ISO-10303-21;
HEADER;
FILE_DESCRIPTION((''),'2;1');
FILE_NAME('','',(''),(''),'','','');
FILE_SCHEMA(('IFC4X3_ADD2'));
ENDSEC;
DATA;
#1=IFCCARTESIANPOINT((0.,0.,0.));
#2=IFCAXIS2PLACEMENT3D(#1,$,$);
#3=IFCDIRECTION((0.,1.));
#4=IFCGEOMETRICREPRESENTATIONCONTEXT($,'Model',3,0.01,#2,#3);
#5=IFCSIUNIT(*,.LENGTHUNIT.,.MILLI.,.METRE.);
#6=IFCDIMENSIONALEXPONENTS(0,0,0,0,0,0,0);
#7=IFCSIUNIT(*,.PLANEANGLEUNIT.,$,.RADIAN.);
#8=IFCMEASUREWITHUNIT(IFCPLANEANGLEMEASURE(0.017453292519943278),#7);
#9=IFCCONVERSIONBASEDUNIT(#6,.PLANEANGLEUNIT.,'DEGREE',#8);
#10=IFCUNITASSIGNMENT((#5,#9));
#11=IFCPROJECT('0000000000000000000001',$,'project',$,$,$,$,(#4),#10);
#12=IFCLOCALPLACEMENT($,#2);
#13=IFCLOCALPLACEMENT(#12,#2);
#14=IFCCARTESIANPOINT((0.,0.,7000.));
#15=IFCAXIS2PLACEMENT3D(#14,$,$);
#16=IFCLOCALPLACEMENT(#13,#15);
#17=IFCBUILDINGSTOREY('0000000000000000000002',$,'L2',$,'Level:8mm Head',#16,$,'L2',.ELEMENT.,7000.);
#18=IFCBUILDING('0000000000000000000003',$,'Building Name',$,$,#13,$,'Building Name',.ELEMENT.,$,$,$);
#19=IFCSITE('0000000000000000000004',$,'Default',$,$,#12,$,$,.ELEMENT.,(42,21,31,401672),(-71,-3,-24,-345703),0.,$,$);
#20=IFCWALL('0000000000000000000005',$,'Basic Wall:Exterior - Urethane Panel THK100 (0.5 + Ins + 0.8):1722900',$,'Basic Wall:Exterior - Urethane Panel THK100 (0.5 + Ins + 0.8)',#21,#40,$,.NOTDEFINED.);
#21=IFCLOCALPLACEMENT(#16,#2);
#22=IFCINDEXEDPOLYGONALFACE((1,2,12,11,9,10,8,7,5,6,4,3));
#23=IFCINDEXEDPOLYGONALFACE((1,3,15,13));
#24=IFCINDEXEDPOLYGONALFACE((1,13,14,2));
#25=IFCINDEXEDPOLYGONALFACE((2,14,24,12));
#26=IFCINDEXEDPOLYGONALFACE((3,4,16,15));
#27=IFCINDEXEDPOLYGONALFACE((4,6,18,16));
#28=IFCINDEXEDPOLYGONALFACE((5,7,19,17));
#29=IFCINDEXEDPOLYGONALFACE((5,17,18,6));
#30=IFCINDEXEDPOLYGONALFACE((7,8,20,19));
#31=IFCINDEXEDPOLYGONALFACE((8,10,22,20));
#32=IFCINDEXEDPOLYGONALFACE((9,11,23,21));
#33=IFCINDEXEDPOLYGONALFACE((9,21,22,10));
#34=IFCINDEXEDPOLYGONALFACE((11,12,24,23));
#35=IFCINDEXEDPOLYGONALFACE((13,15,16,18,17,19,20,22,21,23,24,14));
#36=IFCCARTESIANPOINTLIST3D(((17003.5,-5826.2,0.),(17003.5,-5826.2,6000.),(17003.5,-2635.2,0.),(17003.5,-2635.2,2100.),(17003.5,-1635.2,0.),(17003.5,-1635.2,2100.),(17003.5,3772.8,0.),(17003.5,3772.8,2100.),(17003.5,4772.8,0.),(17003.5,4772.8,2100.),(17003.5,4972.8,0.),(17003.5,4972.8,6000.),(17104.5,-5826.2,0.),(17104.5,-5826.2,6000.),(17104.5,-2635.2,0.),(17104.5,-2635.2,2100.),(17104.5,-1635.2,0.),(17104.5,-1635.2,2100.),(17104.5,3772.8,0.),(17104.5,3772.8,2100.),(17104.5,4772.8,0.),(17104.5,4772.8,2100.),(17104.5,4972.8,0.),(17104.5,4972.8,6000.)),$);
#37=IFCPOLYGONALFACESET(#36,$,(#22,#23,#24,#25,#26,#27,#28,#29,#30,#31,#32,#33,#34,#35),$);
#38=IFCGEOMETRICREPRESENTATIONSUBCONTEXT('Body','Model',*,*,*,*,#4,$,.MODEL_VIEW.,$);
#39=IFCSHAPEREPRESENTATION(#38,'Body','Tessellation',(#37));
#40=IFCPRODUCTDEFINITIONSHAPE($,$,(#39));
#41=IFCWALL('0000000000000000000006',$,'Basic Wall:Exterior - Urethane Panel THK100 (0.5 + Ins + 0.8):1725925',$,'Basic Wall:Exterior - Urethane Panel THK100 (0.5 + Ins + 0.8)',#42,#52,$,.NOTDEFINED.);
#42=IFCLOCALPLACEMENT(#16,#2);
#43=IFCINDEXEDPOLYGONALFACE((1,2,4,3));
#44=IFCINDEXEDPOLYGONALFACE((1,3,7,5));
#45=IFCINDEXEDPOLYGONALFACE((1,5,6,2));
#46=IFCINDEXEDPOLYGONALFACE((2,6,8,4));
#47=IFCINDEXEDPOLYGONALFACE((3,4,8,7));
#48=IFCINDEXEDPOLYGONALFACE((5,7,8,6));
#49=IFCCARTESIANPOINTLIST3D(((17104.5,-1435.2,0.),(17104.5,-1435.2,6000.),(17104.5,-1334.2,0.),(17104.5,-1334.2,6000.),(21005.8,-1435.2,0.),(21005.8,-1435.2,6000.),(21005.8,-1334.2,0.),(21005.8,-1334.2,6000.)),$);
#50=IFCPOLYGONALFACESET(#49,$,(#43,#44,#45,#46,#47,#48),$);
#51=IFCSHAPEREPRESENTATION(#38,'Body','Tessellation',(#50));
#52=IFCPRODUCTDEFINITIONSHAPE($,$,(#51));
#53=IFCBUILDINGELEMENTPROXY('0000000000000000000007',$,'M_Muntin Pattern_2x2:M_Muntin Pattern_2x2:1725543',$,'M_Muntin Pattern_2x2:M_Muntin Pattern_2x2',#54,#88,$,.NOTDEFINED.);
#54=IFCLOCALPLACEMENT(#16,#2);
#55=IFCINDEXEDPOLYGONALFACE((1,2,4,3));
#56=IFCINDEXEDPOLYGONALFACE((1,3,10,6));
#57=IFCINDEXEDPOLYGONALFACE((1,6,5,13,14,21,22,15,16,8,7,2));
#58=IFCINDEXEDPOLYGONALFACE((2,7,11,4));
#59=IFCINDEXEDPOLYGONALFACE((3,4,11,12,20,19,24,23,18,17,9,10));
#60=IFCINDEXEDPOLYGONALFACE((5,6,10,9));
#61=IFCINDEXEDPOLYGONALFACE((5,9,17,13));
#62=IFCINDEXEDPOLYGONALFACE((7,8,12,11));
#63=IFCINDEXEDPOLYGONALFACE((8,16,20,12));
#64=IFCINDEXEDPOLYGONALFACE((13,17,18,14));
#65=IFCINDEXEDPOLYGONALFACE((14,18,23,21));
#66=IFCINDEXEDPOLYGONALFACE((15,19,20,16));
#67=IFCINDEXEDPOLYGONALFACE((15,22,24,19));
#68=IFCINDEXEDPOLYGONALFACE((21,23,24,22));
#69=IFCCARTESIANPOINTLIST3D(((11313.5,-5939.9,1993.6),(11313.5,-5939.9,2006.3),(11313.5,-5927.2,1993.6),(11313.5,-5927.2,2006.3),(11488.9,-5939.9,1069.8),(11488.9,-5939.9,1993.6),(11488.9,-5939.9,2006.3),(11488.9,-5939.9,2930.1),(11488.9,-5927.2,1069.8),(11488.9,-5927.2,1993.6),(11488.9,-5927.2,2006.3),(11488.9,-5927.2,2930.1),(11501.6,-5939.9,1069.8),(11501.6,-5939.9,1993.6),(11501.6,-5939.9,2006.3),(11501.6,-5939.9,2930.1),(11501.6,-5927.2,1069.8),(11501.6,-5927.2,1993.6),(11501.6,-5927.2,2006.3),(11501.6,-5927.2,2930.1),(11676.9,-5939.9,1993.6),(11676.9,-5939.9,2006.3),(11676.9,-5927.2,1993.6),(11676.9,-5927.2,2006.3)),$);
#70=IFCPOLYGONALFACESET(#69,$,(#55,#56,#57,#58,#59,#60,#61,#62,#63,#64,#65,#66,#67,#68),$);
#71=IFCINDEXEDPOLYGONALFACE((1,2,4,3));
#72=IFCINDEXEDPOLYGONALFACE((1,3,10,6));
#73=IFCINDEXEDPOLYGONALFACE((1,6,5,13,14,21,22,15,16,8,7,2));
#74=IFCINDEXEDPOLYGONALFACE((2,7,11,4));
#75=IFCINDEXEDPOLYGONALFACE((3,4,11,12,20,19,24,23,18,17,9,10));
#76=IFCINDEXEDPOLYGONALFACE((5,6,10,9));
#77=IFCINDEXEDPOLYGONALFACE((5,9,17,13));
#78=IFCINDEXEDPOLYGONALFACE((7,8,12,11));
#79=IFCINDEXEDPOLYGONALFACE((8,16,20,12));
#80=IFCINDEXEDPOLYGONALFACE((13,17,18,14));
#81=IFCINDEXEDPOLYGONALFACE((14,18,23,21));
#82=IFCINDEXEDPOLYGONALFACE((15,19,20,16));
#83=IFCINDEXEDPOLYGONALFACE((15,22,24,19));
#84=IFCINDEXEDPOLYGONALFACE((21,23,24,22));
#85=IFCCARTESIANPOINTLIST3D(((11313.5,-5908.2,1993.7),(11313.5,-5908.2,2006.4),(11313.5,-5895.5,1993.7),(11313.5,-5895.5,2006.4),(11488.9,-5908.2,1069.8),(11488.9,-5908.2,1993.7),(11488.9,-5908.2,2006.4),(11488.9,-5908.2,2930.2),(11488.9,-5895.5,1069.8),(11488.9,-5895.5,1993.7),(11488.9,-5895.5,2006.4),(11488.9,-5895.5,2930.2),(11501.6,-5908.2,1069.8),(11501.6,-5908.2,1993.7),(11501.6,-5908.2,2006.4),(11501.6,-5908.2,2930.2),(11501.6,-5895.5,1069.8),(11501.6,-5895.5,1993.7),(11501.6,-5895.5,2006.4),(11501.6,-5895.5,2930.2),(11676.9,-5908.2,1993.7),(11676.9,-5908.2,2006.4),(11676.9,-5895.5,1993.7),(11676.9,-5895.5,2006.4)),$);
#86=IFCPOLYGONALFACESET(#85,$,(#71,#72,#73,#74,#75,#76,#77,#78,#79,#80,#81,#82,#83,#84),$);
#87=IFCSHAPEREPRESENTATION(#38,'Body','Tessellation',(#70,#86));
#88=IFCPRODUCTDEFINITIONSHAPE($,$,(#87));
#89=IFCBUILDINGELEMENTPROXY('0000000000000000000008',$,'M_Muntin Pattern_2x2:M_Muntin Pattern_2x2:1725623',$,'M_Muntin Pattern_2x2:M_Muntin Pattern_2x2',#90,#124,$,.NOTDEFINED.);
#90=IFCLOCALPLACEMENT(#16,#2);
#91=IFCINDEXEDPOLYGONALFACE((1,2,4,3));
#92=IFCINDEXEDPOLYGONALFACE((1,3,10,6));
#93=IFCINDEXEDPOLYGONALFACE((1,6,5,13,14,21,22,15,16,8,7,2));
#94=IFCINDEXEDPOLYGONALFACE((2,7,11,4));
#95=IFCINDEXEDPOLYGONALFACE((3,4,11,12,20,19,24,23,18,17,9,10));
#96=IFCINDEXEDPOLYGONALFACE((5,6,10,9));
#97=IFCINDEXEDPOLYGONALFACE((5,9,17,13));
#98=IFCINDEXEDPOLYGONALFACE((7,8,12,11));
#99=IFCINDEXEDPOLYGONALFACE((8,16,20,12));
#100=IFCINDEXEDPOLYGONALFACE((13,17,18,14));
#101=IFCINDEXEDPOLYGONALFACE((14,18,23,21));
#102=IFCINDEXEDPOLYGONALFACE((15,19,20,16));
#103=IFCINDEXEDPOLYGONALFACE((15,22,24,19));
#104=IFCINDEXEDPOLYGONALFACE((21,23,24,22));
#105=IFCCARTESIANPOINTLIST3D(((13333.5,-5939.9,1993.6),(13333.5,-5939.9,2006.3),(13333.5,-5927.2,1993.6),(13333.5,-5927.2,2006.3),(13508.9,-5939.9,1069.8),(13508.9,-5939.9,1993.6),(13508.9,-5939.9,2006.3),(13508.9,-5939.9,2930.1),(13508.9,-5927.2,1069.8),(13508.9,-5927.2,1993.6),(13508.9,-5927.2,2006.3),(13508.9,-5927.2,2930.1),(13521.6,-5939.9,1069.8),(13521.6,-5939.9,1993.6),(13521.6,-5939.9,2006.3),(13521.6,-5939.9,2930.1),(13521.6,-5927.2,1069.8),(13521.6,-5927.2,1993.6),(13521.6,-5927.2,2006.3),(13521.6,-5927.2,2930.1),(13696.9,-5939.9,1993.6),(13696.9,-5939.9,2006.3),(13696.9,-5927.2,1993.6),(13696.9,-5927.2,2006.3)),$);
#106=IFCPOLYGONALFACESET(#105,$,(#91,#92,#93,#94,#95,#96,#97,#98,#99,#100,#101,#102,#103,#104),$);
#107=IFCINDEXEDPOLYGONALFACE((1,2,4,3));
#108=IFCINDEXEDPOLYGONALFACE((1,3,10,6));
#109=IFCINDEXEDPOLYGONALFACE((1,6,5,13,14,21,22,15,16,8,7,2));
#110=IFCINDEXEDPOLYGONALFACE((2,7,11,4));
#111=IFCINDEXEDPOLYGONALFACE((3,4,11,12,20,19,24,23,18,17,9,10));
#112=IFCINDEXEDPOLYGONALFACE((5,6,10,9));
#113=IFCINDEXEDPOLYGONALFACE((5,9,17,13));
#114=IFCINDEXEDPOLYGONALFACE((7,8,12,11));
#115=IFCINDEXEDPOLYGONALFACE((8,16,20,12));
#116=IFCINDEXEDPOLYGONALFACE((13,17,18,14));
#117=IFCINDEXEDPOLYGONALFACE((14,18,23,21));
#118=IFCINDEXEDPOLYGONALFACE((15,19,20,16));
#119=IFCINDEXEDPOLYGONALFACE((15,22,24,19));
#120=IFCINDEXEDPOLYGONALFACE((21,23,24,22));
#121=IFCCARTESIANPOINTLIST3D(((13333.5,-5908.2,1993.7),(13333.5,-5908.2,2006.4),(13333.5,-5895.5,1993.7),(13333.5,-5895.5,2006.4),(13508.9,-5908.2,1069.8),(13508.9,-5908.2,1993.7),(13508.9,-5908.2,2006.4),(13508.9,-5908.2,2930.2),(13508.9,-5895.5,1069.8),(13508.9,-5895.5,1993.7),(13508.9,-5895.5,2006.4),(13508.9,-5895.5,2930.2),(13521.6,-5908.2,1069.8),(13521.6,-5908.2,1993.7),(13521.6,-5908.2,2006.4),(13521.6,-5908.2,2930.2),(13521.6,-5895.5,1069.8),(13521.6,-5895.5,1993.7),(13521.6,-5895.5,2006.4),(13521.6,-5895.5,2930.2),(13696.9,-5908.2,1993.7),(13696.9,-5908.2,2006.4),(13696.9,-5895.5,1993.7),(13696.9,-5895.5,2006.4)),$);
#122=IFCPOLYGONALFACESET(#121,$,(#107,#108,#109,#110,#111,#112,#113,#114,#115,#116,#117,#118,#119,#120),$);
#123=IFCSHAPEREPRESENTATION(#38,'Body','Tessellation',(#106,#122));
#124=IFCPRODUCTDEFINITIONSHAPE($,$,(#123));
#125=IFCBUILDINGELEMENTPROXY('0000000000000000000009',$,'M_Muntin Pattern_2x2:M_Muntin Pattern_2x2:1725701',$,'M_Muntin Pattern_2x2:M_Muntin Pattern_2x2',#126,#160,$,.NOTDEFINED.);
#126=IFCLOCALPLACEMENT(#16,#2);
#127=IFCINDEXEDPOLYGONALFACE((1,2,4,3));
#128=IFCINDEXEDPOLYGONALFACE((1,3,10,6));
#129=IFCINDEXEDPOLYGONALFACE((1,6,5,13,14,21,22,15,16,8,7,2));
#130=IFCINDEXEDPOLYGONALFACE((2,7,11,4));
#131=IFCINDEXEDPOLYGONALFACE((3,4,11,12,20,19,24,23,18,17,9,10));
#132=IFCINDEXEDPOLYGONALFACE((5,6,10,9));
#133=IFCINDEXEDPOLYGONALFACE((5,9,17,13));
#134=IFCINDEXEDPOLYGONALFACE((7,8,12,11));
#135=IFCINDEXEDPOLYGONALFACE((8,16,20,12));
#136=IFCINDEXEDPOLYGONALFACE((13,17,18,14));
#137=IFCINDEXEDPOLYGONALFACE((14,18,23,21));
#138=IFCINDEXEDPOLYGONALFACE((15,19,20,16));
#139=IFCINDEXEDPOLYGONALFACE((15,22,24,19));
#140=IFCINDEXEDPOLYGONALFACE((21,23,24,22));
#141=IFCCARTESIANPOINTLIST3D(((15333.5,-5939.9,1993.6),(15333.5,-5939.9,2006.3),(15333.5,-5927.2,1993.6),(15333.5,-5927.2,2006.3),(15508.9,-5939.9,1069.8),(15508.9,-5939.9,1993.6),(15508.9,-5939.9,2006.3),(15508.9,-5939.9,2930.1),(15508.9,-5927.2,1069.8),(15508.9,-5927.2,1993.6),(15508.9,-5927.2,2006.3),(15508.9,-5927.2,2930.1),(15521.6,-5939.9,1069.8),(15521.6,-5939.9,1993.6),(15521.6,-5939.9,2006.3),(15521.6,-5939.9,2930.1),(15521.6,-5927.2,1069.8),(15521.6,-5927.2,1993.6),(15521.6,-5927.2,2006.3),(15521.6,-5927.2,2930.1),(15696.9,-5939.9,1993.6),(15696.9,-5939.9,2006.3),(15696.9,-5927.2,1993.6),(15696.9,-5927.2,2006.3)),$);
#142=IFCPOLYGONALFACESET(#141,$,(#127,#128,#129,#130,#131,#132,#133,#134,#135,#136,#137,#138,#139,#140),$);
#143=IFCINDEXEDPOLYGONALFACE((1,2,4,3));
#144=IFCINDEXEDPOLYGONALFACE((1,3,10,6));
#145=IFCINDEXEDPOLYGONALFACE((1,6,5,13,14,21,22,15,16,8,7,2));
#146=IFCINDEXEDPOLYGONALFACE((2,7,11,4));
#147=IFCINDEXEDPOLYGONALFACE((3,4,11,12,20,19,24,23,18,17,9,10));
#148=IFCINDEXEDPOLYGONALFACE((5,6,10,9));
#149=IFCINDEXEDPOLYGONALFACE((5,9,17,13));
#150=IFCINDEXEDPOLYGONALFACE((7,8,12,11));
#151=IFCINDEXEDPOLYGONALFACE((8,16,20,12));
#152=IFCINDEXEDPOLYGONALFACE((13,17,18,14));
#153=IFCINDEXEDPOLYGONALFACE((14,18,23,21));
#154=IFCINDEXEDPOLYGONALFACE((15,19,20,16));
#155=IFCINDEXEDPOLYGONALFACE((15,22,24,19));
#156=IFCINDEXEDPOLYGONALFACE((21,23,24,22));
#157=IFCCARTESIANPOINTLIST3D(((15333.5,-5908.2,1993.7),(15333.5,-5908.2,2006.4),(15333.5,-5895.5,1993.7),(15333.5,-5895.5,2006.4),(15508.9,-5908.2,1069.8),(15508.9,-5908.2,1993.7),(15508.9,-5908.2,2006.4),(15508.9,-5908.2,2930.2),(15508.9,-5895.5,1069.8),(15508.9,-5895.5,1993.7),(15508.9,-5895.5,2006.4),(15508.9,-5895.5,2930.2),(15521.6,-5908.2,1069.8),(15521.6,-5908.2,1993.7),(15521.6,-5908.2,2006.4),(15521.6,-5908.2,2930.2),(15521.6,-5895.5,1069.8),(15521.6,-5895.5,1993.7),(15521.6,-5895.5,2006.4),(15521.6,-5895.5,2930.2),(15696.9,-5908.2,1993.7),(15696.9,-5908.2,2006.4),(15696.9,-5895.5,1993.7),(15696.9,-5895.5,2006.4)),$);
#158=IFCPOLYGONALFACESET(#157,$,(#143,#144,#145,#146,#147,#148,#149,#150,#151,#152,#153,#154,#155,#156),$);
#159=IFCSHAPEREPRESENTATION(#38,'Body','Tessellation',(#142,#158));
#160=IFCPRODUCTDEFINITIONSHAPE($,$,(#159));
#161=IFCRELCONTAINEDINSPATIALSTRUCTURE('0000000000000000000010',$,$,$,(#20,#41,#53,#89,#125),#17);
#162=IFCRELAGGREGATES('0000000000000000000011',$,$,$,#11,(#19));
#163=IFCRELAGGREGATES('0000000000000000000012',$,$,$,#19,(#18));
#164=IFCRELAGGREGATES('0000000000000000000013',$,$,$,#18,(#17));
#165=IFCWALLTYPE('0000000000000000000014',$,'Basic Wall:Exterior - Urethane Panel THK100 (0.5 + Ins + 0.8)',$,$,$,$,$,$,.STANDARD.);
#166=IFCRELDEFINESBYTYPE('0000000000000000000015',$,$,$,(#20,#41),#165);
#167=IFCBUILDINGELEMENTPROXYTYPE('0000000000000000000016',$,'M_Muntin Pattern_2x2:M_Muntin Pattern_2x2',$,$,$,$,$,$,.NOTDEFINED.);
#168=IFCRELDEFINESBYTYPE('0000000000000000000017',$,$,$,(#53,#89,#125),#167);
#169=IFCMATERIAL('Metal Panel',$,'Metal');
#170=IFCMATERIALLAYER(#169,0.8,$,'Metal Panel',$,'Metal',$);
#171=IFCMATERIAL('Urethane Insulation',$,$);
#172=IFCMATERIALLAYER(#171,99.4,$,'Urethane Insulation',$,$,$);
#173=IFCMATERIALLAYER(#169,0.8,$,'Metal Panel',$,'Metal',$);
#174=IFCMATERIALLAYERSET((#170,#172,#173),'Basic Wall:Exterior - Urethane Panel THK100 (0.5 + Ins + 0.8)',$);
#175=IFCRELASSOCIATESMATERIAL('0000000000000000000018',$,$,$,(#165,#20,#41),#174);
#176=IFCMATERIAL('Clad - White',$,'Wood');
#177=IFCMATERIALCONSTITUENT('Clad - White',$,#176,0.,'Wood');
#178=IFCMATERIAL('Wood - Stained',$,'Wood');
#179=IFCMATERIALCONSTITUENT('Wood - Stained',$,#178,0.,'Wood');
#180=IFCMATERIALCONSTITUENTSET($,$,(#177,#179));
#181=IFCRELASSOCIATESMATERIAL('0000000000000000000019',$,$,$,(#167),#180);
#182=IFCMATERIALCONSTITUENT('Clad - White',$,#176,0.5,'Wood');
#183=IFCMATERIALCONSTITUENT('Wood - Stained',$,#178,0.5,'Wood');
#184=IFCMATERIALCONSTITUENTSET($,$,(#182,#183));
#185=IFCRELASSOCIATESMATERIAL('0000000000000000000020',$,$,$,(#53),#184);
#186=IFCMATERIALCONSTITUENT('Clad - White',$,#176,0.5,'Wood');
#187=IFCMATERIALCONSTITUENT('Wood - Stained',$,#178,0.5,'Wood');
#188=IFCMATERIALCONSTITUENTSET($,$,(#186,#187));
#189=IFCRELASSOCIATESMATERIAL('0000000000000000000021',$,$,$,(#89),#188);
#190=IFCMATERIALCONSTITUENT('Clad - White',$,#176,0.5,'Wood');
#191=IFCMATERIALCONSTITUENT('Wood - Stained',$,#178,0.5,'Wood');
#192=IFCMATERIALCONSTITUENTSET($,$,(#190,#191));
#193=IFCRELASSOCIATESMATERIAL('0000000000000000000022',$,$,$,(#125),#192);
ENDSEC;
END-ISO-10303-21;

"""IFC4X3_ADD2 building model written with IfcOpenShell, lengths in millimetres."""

from ifc_helpers import new_model, entity, si_unit, converted_unit, direction, frame, frame_2d, origin, place, context, subcontext, project, spatial, polyline, rectangle, outline, extrude, source, transform, mapped, material, layer, layer_set, constituent, constituent_set, type_object, type_shapes, element, save


model = new_model("IFC4X3_ADD2")

# Units and contexts
model_context = context("Model", 3, precision=0.01, world=origin(), true_north=direction((0.0, 1.0)))
body_context = subcontext(model_context, "Body", "Model", "MODEL_VIEW")
ifc_project = project(units=[si_unit("LENGTHUNIT", "METRE", prefix="MILLI"), converted_unit("PLANEANGLEUNIT", "DEGREE", entity("IfcPlaneAngleMeasure", 0.017453292519943278), si_unit("PLANEANGLEUNIT", "RADIAN"), dimensions=[0, 0, 0, 0, 0, 0, 0])], contexts=[model_context])

# Site, building, storey
site_placement = place(None, origin())
site = spatial("IfcSite", under=ifc_project, at=site_placement, Name="Default", CompositionType="ELEMENT", RefLatitude=(42, 21, 31, 401672), RefLongitude=(-71, -3, -24, -345703), RefElevation=0.0)
building_placement = place(site_placement, origin())
building = spatial("IfcBuilding", under=site, at=building_placement, Name="Building Name", LongName="Building Name", CompositionType="ELEMENT")
storey_placement = place(building_placement, frame((0.0, 0.0, 7000.0)))
storey = spatial("IfcBuildingStorey", under=building, at=storey_placement, Name="L2", ObjectType="Level:8mm Head", LongName="L2", CompositionType="ELEMENT", Elevation=7000.0)

# Wall, openings
ifc_material_1 = material(Name="Metal Panel", Category="Metal")
ifc_layer_1 = layer(ifc_material_1, 0.8, Name="Metal Panel", Category="Metal")
ifc_material_2 = material(Name="Urethane Insulation")
ifc_layer_2 = layer(ifc_material_2, 99.4, Name="Urethane Insulation")
ifc_layer_3 = layer(ifc_material_1, 0.8, Name="Metal Panel", Category="Metal")
ifc_layer_set = layer_set([ifc_layer_1, ifc_layer_2, ifc_layer_3], Name="Basic Wall:Exterior - Urethane Panel THK100 (0.5 + Ins + 0.8)")
wall_type = type_object("IfcWallType", Name="Basic Wall:Exterior - Urethane Panel THK100 (0.5 + Ins + 0.8)", PredefinedType="STANDARD", material=ifc_layer_set)
wall_1_placement = place(storey_placement, frame((17054.0, -5826.2, 0.0), z_axis=(0.0, 0.0, 1.0), x_axis=(0.0, 1.0, 0.0)))
wall_1 = element("IfcWall", 1, at=wall_1_placement, inside=storey, type_object=wall_type, material=ifc_layer_set, Name="Basic Wall:Exterior - Urethane Panel THK100 (0.5 + Ins + 0.8):1722900", ObjectType="Basic Wall:Exterior - Urethane Panel THK100 (0.5 + Ins + 0.8)", PredefinedType="NOTDEFINED", context=body_context, shape_type="SweptSolid", body=[
    extrude(rectangle(XDim=10799.0, YDim=101.0, at=frame_2d((5399.5, 0.0), x_axis=(1.0, 0.0))), origin(), (0.0, 0.0, 1.0), 6000.0),
])
opening_1_placement = place(wall_1_placement, frame((10599.0, 50.5, 0.0)))
element("IfcOpeningElement", 2, at=opening_1_placement, cuts=wall_1, PredefinedType="OPENING", context=body_context, shape_type="SweptSolid", body=[
    extrude(rectangle(XDim=2100.0, YDim=1000.0, at=frame_2d((1050.0, 500.0), x_axis=(1.0, 0.0))), frame((0.0, 0.0, 0.0), z_axis=(0.0, -1.0, 0.0), x_axis=(0.0, 0.0, 1.0)), (0.0, 0.0, 1.0), 101.0),
])
opening_2_placement = place(wall_1_placement, frame((4191.0, 50.5, 0.0)))
element("IfcOpeningElement", 3, at=opening_2_placement, cuts=wall_1, PredefinedType="OPENING", context=body_context, shape_type="SweptSolid", body=[
    extrude(rectangle(XDim=2100.0, YDim=1000.0, at=frame_2d((1050.0, 500.0), x_axis=(1.0, 0.0))), frame((0.0, 0.0, 0.0), z_axis=(0.0, -1.0, 0.0), x_axis=(0.0, 0.0, 1.0)), (0.0, 0.0, 1.0), 101.0),
])

# Wall
wall_2_placement = place(storey_placement, frame((17104.5, -1384.7, 0.0)))
element("IfcWall", 4, at=wall_2_placement, inside=storey, type_object=wall_type, material=ifc_layer_set, Name="Basic Wall:Exterior - Urethane Panel THK100 (0.5 + Ins + 0.8):1725925", ObjectType="Basic Wall:Exterior - Urethane Panel THK100 (0.5 + Ins + 0.8)", PredefinedType="NOTDEFINED", context=body_context, shape_type="SweptSolid", body=[
    extrude(rectangle(XDim=3901.3, YDim=101.0, at=frame_2d((1950.6, 0.0), x_axis=(-1.0, 0.0))), origin(), (0.0, 0.0, 1.0), 6000.0),
])

# Building element proxies
ifc_material_3 = material(Name="Clad - White", Category="Wood")
ifc_constituent_1 = constituent(ifc_material_3, Name="Clad - White", Category="Wood", fraction=0.5)
ifc_material_4 = material(Name="Wood - Stained", Category="Wood")
ifc_constituent_2 = constituent(ifc_material_4, Name="Wood - Stained", Category="Wood", fraction=0.5)
ifc_constituent_set_1 = constituent_set(constituents=[ifc_constituent_1, ifc_constituent_2])
ifc_constituent_3 = constituent(ifc_material_3, Name="Clad - White", Category="Wood", fraction=0.0)
ifc_constituent_4 = constituent(ifc_material_4, Name="Wood - Stained", Category="Wood", fraction=0.0)
ifc_constituent_set_2 = constituent_set(constituents=[ifc_constituent_3, ifc_constituent_4])
building_element_proxy_type_1 = type_object("IfcBuildingElementProxyType", Name="M_Muntin Pattern_2x2:M_Muntin Pattern_2x2", PredefinedType="NOTDEFINED", material=ifc_constituent_set_2)
shared_shape_1 = source(origin(), body_context, "Body", "SweptSolid", [
    extrude(outline(polyline([(6.4, -6.4), (930.1, -6.4), (930.1, 6.3), (6.4, 6.3), (6.4, 181.7), (-6.3, 181.7), (-6.3, 6.3), (-930.2, 6.3), (-930.2, -6.4), (-6.3, -6.4), (-6.3, -181.7), (6.4, -181.7), (6.4, -6.4)])), frame((0.0, 9.5, 930.1), z_axis=(0.0, 1.0, 0.0), x_axis=(0.0, 0.0, 1.0)), (0.0, 0.0, 1.0), 12.7),
    extrude(outline(polyline([(6.4, -6.4), (930.2, -6.4), (930.2, 6.3), (6.4, 6.3), (6.4, 181.7), (-6.3, 181.7), (-6.3, 6.3), (-930.2, 6.3), (-930.2, -6.4), (-6.3, -6.4), (-6.3, -181.7), (6.4, -181.7), (6.4, -6.4)])), frame((0.0, -22.2, 930.2), z_axis=(0.0, 1.0, 0.0), x_axis=(0.0, 0.0, 1.0)), (0.0, 0.0, 1.0), 12.7),
])
type_shapes(building_element_proxy_type_1, [shared_shape_1])
proxy_1_placement = place(storey_placement, frame((11495.2, -5917.7, 1069.8), z_axis=(0.0, 0.0, 1.0), x_axis=(-1.0, 0.0, 0.0)))
element("IfcBuildingElementProxy", 5, at=proxy_1_placement, inside=storey, type_object=building_element_proxy_type_1, material=ifc_constituent_set_1, Name="M_Muntin Pattern_2x2:M_Muntin Pattern_2x2:1725543", ObjectType="M_Muntin Pattern_2x2:M_Muntin Pattern_2x2", PredefinedType="NOTDEFINED", context=body_context, shape_type="MappedRepresentation", body=[
    mapped(shared_shape_1, transform((0.0, 0.0, 0.0), scale=1.0)),
])
ifc_constituent_5 = constituent(ifc_material_3, Name="Clad - White", Category="Wood", fraction=0.5)
ifc_constituent_6 = constituent(ifc_material_4, Name="Wood - Stained", Category="Wood", fraction=0.5)
ifc_constituent_set_3 = constituent_set(constituents=[ifc_constituent_5, ifc_constituent_6])
proxy_2_placement = place(storey_placement, frame((13515.2, -5917.7, 1069.8), z_axis=(0.0, 0.0, 1.0), x_axis=(-1.0, 0.0, 0.0)))
element("IfcBuildingElementProxy", 6, at=proxy_2_placement, inside=storey, type_object=building_element_proxy_type_1, material=ifc_constituent_set_3, Name="M_Muntin Pattern_2x2:M_Muntin Pattern_2x2:1725623", ObjectType="M_Muntin Pattern_2x2:M_Muntin Pattern_2x2", PredefinedType="NOTDEFINED", context=body_context, shape_type="MappedRepresentation", body=[
    mapped(shared_shape_1, transform((0.0, 0.0, 0.0), scale=1.0)),
])
ifc_constituent_7 = constituent(ifc_material_3, Name="Clad - White", Category="Wood", fraction=0.5)
ifc_constituent_8 = constituent(ifc_material_4, Name="Wood - Stained", Category="Wood", fraction=0.5)
ifc_constituent_set_4 = constituent_set(constituents=[ifc_constituent_7, ifc_constituent_8])
proxy_3_placement = place(storey_placement, frame((15515.2, -5917.7, 1069.8), z_axis=(0.0, 0.0, 1.0), x_axis=(-1.0, 0.0, 0.0)))
element("IfcBuildingElementProxy", 7, at=proxy_3_placement, inside=storey, type_object=building_element_proxy_type_1, material=ifc_constituent_set_4, Name="M_Muntin Pattern_2x2:M_Muntin Pattern_2x2:1725701", ObjectType="M_Muntin Pattern_2x2:M_Muntin Pattern_2x2", PredefinedType="NOTDEFINED", context=body_context, shape_type="MappedRepresentation", body=[
    mapped(shared_shape_1, transform((0.0, 0.0, 0.0), scale=1.0)),
])

save(model, "model.ifc")
